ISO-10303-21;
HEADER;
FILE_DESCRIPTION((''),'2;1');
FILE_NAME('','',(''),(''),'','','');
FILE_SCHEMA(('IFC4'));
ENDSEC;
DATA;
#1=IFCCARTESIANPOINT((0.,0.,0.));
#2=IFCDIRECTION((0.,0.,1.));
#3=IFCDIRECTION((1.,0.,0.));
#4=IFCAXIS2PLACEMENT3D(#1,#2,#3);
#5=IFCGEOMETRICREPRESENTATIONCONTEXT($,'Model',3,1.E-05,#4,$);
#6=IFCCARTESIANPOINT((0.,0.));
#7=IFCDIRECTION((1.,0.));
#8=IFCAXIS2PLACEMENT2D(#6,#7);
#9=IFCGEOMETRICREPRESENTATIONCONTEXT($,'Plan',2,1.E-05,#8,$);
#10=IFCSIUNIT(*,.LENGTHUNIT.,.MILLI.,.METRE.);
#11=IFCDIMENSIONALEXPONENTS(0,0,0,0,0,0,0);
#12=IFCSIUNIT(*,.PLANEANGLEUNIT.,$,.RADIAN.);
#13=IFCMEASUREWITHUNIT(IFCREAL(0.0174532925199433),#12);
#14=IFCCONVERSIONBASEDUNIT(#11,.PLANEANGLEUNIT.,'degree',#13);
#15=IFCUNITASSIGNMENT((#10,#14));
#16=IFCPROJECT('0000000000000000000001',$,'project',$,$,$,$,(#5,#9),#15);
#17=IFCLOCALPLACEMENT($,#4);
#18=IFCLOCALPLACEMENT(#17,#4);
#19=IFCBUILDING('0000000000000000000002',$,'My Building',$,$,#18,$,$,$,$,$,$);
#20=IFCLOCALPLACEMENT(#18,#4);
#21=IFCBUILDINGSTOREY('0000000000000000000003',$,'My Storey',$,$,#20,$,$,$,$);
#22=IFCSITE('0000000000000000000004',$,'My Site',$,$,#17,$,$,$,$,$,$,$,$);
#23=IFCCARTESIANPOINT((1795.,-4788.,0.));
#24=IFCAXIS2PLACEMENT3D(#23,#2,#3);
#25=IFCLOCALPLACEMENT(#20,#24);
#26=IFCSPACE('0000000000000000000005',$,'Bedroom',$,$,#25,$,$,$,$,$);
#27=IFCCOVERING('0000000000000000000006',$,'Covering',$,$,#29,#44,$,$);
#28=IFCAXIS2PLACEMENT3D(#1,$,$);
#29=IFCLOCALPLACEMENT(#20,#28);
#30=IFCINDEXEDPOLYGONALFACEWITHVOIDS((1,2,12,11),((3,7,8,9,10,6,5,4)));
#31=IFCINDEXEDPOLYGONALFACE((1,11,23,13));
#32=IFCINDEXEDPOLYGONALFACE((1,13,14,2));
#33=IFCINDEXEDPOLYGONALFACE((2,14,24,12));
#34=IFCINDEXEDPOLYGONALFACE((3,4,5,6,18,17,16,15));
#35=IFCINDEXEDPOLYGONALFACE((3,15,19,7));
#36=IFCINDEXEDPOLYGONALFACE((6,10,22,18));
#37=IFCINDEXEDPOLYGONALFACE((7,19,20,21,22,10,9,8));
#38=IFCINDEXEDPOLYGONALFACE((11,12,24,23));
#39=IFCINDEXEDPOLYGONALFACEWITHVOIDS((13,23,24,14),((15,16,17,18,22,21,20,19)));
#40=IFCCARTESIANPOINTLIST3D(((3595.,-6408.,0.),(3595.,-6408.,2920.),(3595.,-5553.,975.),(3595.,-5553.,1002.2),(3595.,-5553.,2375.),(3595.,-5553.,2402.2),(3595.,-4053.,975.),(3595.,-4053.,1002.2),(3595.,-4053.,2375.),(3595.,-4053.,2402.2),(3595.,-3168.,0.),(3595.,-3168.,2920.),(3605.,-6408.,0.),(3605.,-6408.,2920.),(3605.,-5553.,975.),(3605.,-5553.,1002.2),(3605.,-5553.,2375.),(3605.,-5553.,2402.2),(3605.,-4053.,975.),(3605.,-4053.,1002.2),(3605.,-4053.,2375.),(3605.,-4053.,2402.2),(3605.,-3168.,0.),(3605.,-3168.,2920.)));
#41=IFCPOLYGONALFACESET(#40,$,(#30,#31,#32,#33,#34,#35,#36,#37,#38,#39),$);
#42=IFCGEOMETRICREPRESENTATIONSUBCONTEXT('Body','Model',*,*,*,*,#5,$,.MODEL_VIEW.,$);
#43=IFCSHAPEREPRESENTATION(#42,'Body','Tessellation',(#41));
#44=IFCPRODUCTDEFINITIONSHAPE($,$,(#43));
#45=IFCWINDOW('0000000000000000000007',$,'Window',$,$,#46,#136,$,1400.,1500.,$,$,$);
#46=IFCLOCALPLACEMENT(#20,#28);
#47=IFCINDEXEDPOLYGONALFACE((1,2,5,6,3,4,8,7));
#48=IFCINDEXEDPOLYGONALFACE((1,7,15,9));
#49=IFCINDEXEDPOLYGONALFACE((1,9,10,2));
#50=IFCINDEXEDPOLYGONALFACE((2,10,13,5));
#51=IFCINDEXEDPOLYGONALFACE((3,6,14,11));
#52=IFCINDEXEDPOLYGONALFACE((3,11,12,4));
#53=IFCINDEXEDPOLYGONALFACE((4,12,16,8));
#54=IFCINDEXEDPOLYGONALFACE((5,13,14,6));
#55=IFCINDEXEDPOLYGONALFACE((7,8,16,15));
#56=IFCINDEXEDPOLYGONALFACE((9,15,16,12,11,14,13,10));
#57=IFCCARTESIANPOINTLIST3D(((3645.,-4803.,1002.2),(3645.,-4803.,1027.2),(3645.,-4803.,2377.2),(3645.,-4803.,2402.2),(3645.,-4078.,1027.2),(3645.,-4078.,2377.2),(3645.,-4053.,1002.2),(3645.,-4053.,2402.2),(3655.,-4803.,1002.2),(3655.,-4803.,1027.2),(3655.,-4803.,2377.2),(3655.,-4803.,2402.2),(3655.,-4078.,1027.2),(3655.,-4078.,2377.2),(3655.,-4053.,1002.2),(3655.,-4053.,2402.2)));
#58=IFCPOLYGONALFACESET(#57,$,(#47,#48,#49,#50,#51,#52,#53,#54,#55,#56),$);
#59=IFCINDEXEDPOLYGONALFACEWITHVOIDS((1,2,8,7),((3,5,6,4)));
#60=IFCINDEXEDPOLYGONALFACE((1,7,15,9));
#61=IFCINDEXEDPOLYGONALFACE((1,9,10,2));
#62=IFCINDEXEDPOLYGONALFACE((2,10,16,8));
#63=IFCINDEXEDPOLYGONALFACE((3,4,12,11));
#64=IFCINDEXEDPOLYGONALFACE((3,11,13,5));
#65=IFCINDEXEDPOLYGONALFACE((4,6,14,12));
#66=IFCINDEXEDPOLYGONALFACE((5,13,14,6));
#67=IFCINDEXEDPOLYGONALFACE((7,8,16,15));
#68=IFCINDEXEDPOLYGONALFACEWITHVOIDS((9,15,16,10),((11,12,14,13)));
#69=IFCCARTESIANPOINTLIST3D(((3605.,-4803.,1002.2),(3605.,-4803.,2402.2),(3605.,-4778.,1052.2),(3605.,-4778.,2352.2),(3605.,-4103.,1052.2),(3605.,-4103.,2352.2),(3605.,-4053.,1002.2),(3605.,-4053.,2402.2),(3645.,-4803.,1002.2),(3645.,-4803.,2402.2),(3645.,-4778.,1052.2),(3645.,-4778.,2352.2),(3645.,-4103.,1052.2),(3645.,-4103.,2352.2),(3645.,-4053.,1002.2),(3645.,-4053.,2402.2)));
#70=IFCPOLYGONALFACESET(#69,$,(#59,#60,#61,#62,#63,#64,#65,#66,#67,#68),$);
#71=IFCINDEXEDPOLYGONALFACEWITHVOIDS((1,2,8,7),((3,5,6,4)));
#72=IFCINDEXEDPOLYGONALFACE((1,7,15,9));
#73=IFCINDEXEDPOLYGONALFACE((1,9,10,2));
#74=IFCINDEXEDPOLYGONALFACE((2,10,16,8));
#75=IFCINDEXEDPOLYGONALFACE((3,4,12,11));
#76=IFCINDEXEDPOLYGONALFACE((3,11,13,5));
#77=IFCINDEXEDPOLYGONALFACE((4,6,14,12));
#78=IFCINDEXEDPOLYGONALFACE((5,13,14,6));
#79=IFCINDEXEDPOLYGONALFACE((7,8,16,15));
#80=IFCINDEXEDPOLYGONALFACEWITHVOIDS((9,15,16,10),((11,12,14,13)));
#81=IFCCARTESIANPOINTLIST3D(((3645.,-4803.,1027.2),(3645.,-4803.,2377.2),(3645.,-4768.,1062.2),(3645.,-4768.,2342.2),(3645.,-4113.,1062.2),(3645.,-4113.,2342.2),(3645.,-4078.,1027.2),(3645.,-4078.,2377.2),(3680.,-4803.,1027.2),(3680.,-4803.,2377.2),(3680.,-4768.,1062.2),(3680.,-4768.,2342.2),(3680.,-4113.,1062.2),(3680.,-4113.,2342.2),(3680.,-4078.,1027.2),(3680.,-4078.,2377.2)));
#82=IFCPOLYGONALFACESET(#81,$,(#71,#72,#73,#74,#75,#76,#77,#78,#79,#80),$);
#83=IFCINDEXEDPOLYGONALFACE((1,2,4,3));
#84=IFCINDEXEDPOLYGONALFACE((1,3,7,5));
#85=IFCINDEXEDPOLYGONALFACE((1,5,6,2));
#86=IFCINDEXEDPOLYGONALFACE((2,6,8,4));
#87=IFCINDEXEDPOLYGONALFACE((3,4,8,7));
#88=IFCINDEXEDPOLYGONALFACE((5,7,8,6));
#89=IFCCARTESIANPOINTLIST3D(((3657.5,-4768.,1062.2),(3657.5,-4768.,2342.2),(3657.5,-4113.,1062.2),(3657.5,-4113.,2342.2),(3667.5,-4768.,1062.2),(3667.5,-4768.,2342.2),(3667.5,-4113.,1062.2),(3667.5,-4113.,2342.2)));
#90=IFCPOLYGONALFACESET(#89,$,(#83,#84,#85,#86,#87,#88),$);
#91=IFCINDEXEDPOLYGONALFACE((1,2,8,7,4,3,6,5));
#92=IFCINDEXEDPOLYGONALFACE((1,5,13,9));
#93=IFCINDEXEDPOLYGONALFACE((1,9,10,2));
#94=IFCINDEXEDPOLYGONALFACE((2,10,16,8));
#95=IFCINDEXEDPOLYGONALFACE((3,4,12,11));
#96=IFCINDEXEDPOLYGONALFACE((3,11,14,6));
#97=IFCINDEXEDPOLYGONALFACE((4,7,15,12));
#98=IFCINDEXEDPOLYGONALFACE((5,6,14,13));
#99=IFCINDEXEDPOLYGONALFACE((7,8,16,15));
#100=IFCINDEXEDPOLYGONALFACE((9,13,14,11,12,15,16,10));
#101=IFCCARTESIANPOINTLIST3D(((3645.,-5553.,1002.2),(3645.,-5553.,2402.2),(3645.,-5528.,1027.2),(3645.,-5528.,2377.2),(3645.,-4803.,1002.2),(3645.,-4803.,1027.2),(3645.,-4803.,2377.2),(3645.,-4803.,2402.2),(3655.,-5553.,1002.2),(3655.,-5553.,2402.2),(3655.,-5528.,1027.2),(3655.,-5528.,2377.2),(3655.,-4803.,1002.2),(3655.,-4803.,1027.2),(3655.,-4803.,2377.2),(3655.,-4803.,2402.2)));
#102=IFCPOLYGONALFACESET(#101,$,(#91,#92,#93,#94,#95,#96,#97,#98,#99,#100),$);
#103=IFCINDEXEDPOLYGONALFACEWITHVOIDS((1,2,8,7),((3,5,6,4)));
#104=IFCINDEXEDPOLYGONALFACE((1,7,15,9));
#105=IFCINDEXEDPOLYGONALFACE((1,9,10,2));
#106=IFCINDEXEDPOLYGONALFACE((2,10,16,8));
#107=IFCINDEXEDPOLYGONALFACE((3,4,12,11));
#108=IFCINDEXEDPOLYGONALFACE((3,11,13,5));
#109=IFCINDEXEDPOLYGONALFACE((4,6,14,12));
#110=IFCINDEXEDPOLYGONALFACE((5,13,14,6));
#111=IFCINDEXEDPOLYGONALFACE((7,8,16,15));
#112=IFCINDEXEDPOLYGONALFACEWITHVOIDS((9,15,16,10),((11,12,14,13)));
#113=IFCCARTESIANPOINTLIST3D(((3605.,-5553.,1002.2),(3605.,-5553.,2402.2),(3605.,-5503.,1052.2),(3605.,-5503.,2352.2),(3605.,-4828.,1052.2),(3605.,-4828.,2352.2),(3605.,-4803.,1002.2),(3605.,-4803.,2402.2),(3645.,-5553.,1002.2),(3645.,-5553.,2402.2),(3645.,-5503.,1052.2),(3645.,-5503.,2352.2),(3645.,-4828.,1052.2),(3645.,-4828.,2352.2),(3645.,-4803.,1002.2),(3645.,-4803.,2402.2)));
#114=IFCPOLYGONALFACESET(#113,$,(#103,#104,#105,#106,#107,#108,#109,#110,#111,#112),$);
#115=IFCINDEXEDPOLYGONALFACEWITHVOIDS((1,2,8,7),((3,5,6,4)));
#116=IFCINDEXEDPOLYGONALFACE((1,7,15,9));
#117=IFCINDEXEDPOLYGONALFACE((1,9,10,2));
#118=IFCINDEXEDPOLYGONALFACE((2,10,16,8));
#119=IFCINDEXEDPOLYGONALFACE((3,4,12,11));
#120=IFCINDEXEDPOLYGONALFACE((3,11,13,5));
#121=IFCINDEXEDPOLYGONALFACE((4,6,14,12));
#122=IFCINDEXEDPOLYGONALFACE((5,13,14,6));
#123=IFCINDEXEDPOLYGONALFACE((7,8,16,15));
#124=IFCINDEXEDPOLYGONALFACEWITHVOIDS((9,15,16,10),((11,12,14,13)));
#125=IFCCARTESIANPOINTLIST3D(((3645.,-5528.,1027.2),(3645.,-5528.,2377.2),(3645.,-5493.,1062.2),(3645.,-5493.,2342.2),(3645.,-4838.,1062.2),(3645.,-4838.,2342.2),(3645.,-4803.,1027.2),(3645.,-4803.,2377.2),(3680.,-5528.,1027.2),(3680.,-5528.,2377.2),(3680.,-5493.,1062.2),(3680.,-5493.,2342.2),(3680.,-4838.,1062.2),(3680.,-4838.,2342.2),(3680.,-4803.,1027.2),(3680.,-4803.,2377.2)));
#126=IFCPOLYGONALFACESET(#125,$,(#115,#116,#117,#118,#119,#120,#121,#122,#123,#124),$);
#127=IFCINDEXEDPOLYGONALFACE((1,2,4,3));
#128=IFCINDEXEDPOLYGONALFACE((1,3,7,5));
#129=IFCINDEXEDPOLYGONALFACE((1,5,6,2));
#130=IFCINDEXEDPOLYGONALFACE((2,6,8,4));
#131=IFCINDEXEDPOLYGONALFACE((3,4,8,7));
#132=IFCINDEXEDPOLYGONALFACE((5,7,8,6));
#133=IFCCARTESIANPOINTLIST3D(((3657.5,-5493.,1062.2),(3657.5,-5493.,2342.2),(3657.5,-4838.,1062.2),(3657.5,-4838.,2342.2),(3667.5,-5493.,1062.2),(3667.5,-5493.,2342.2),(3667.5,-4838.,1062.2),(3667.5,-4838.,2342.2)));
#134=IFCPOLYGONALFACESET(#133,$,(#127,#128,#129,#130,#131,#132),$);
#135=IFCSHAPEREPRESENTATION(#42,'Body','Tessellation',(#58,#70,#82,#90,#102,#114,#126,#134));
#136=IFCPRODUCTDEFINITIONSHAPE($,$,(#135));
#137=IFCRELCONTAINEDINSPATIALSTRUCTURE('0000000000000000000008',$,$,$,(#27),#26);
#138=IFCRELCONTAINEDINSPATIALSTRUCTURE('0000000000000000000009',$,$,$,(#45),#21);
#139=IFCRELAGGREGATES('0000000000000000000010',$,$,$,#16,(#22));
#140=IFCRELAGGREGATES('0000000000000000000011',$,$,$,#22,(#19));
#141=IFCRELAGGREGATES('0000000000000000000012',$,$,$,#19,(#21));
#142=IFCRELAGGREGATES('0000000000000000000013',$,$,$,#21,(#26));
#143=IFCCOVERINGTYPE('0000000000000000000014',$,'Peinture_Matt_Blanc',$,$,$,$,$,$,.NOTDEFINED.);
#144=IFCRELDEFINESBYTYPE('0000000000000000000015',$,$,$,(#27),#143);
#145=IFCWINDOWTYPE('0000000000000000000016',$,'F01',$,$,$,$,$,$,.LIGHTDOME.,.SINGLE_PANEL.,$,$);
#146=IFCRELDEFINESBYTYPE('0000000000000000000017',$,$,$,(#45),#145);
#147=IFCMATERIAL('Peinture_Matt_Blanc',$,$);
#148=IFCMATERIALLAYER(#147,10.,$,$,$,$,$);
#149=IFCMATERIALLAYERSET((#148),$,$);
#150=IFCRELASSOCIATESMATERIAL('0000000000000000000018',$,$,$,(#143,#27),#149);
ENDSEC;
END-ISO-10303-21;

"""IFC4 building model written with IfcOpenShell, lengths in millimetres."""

from ifc_helpers import new_model, entity, si_unit, converted_unit, frame, origin_with_axes, origin_2d_with_axis, place, context, subcontext, project, spatial, line, indexed_curve, outline, extrude, clip, halfspace, shape, source, transform, mapped, material, layer, layer_set, layer_usage, type_object, type_shapes, element, fill, save


model = new_model("IFC4")

# Units and contexts
model_context = context("Model", 3, precision=1e-05, world=origin_with_axes())
plan_context = context("Plan", 2, precision=1e-05, world=origin_2d_with_axis())
body_context_1 = subcontext(model_context, "Body", "Model", "MODEL_VIEW")
body_context_2 = subcontext(plan_context, "Body", "Plan", "PLAN_VIEW")
ifc_project = project(units=[si_unit("LENGTHUNIT", "METRE", prefix="MILLI"), converted_unit("PLANEANGLEUNIT", "degree", entity("IfcReal", 0.0174532925199433), si_unit("PLANEANGLEUNIT", "RADIAN"), dimensions=[0, 0, 0, 0, 0, 0, 0])], contexts=[model_context, plan_context])

# Site, building, storey
site_placement = place(None, origin_with_axes())
site = spatial("IfcSite", under=ifc_project, at=site_placement, Name="My Site")
building_placement = place(site_placement, origin_with_axes())
building = spatial("IfcBuilding", under=site, at=building_placement, Name="My Building")
storey_placement = place(building_placement, origin_with_axes())
storey = spatial("IfcBuildingStorey", under=building, at=storey_placement, Name="My Storey")

# Shared definitions
space_placement = place(storey_placement, frame((1795.0, -4788.0, 0.0), z_axis=(0.0, 0.0, 1.0), x_axis=(1.0, 0.0, 0.0)))
space = spatial("IfcSpace", under=storey, at=space_placement, Name="Bedroom")

# Covering, openings, window
ifc_material_1 = material(Name="Peinture_Matt_Blanc")
ifc_layer_1 = layer(ifc_material_1, 10.0)
ifc_layer_set_1 = layer_set([ifc_layer_1])
ifc_layer_usage_1 = layer_usage(ifc_layer_set_1, "AXIS2", "POSITIVE", 0.0)
covering_type_1 = type_object("IfcCoveringType", Name="Peinture_Matt_Blanc", PredefinedType="NOTDEFINED", material=ifc_layer_set_1)
covering_1_placement = place(space_placement, frame((1810.0, -1620.0, 0.0), z_axis=(0.0, 0.0, 1.0), x_axis=(0.000002, 1.0, 0.0)))
covering_1 = element("IfcCovering", 1, at=covering_1_placement, inside=space, type_object=covering_type_1, material=ifc_layer_usage_1, Name="Covering", context=body_context_1, shape_type="Clipping", body=[
    clip(clip(extrude(outline(indexed_curve([(0.0, 0.0), (0.0, 10.0), (3240.0, 10.0), (3240.0, 0.0), (0.0, 0.0)], self_intersect=False)), origin_with_axes(), (0.0, 0.0, 1.0), 2920.0), halfspace(frame((0.0, 0.0, 2920.0), z_axis=(0.0, 0.0, 1.0), x_axis=(-1.0, 0.0, 0.0)), False)), halfspace(frame((0.0, 0.0, 2920.0), z_axis=(0.0, 0.0, 1.0), x_axis=(-1.0, 0.0, 0.0)), False)),
])
shared_shape_1 = source(origin_with_axes(), body_context_1, "Body", "SweptSolid", [
    extrude(outline(indexed_curve([(0.0, 0.0), (1500.0, 0.0), (1500.0, 1400.0), (0.0, 1400.0)], segments=[line(1, 2, 3, 4, 1)])), frame((0.0, -100.0, 0.0), z_axis=(0.0, -1.0, 0.0), x_axis=(1.0, 0.0, 0.0)), (0.0, 0.0, -1.0), 210.0),
])
opening_1_placement = place(covering_1_placement, frame((2355.0, -75.0, 975.0), z_axis=(0.0, 0.0, 1.0), x_axis=(-1.0, 0.0, 0.0)))
opening_1 = element("IfcOpeningElement", 2, at=opening_1_placement, cuts=covering_1, PredefinedType="OPENING", context=body_context_1, shape_type="MappedRepresentation", body=[
    mapped(shared_shape_1, transform((0.0, 0.0, 0.0), x_axis=(1.0, 0.0, 0.0), y_axis=(0.0, 1.0, 0.0), z_axis=(0.0, 0.0, 1.0), scale=1.0)),
])
shared_shape_2 = source(origin_with_axes(), body_context_1, "Body", "SweptSolid", [
    extrude(outline(indexed_curve([(0.0, 0.0), (1500.0, 0.0), (1500.0, 1400.0), (0.0, 1400.0)], segments=[line(3, 2), line(2, 1), line(1, 4), line(4, 3)], self_intersect=False)), frame((0.0, -100.0, 0.0), z_axis=(0.0, -1.0, 0.0), x_axis=(1.0, 0.0, 0.0)), (0.0, 0.0, -1.0), 400.0),
])
opening_2_placement = place(covering_1_placement, frame((855.0, -200.0, 1002.2), z_axis=(0.0, 0.0, 1.0), x_axis=(1.0, 0.0, 0.0)))
element("IfcOpeningElement", 3, at=opening_2_placement, cuts=covering_1, PredefinedType="OPENING", context=body_context_1, shape_type="MappedRepresentation", body=[
    mapped(shared_shape_2, transform((0.0, 0.0, 0.0), x_axis=(1.0, 0.0, 0.0), y_axis=(0.0, 1.0, 0.0), z_axis=(0.0, 0.0, 1.0), scale=1.0)),
])
window_type = type_object("IfcWindowType", Name="F01", PartitioningType="SINGLE_PANEL", PredefinedType="LIGHTDOME")
shared_shape_3 = source(origin_with_axes(), body_context_1, "Body", "SweptSolid", [
    extrude(outline(indexed_curve([(750.0, 0.0), (0.0, 0.0), (0.0, 1400.0), (750.0, 1400.0), (750.0, 1375.0), (25.0, 1375.0), (25.0, 25.0), (750.0, 25.0)], segments=[line(1, 2, 3, 4, 5, 6, 7, 8, 1)])), frame((0.0, 90.0, 0.0), z_axis=(0.0, -1.0, 0.0), x_axis=(1.0, 0.0, 0.0)), (0.0, 0.0, -1.0), 10.0),
    extrude(outline(indexed_curve([(0.0, 0.0), (750.0, 0.0), (750.0, 1400.0), (0.0, 1400.0)], segments=[line(1, 2, 3, 4, 1)]), holes=[indexed_curve([(50.0, 50.0), (725.0, 50.0), (725.0, 1350.0), (50.0, 1350.0)], segments=[line(1, 2, 3, 4, 1)])]), frame((0.0, 50.0, 0.0), z_axis=(0.0, -1.0, 0.0), x_axis=(1.0, 0.0, 0.0)), (0.0, 0.0, -1.0), 40.0),
    extrude(outline(indexed_curve([(0.0, 0.0), (725.0, 0.0), (725.0, 1350.0), (0.0, 1350.0)], segments=[line(1, 2, 3, 4, 1)]), holes=[indexed_curve([(35.0, 35.0), (690.0, 35.0), (690.0, 1315.0), (35.0, 1315.0)], segments=[line(1, 2, 3, 4, 1)])]), frame((25.0, 90.0, 25.0), z_axis=(0.0, -1.0, 0.0), x_axis=(1.0, 0.0, 0.0)), (0.0, 0.0, -1.0), 35.0),
    extrude(outline(indexed_curve([(35.0, 35.0), (690.0, 35.0), (690.0, 1315.0), (35.0, 1315.0)], segments=[line(1, 2, 3, 4, 1)])), frame((25.0, 102.5, 25.0), z_axis=(0.0, -1.0, 0.0), x_axis=(1.0, 0.0, 0.0)), (0.0, 0.0, -1.0), 10.0),
    extrude(outline(indexed_curve([(0.0, 1400.0), (750.0, 1400.0), (750.0, 0.0), (0.0, 0.0), (0.0, 25.0), (725.0, 25.0), (725.0, 1375.0), (0.0, 1375.0)], segments=[line(1, 2, 3, 4, 5, 6, 7, 8, 1)])), frame((750.0, 90.0, 0.0), z_axis=(0.0, -1.0, 0.0), x_axis=(1.0, 0.0, 0.0)), (0.0, 0.0, -1.0), 10.0),
    extrude(outline(indexed_curve([(0.0, 0.0), (750.0, 0.0), (750.0, 1400.0), (0.0, 1400.0)], segments=[line(1, 2, 3, 4, 1)]), holes=[indexed_curve([(25.0, 50.0), (700.0, 50.0), (700.0, 1350.0), (25.0, 1350.0)], segments=[line(1, 2, 3, 4, 1)])]), frame((750.0, 50.0, 0.0), z_axis=(0.0, -1.0, 0.0), x_axis=(1.0, 0.0, 0.0)), (0.0, 0.0, -1.0), 40.0),
    extrude(outline(indexed_curve([(0.0, 0.0), (725.0, 0.0), (725.0, 1350.0), (0.0, 1350.0)], segments=[line(1, 2, 3, 4, 1)]), holes=[indexed_curve([(35.0, 35.0), (690.0, 35.0), (690.0, 1315.0), (35.0, 1315.0)], segments=[line(1, 2, 3, 4, 1)])]), frame((750.0, 90.0, 25.0), z_axis=(0.0, -1.0, 0.0), x_axis=(1.0, 0.0, 0.0)), (0.0, 0.0, -1.0), 35.0),
    extrude(outline(indexed_curve([(35.0, 35.0), (690.0, 35.0), (690.0, 1315.0), (35.0, 1315.0)], segments=[line(1, 2, 3, 4, 1)])), frame((750.0, 102.5, 25.0), z_axis=(0.0, -1.0, 0.0), x_axis=(1.0, 0.0, 0.0)), (0.0, 0.0, -1.0), 10.0),
])
shared_shape_4 = source(origin_with_axes(), body_context_2, "Body", "Curve2D", [
    entity("IfcIndexedPolyCurve", entity("IfcCartesianPointList2D", [[50.0, 50.0], [725.0, 50.0]])),
    entity("IfcIndexedPolyCurve", entity("IfcCartesianPointList2D", [[0.0, 100.0], [25.0, 100.0], [25.0, 90.0], [50.0, 90.0], [50.0, 50.0], [0.0, 50.0]]), [entity("IfcLineIndex", [1, 2, 3, 4, 5, 6, 1])]),
    entity("IfcIndexedPolyCurve", entity("IfcCartesianPointList2D", [[750.0, 100.0], [750.0, 100.0], [750.0, 90.0], [725.0, 90.0], [725.0, 50.0], [750.0, 50.0]])),
    entity("IfcIndexedPolyCurve", entity("IfcCartesianPointList2D", [[25.0, 90.0], [60.0, 90.0], [60.0, 125.0], [25.0, 125.0]]), [entity("IfcLineIndex", [1, 2, 3, 4, 1])]),
    entity("IfcIndexedPolyCurve", entity("IfcCartesianPointList2D", [[750.0, 90.0], [715.0, 90.0], [715.0, 125.0], [750.0, 125.0]]), [entity("IfcLineIndex", [1, 2, 3, 4, 1])]),
    entity("IfcIndexedPolyCurve", entity("IfcCartesianPointList2D", [[60.0, 90.0], [715.0, 90.0]])),
    entity("IfcIndexedPolyCurve", entity("IfcCartesianPointList2D", [[60.0, 125.0], [715.0, 125.0]])),
    entity("IfcIndexedPolyCurve", entity("IfcCartesianPointList2D", [[60.0, 107.5], [715.0, 107.5]])),
    entity("IfcIndexedPolyCurve", entity("IfcCartesianPointList2D", [[775.0, 50.0], [1450.0, 50.0]])),
    entity("IfcIndexedPolyCurve", entity("IfcCartesianPointList2D", [[750.0, 100.0], [750.0, 100.0], [750.0, 90.0], [775.0, 90.0], [775.0, 50.0], [750.0, 50.0]])),
    entity("IfcIndexedPolyCurve", entity("IfcCartesianPointList2D", [[1500.0, 100.0], [1475.0, 100.0], [1475.0, 90.0], [1450.0, 90.0], [1450.0, 50.0], [1500.0, 50.0]]), [entity("IfcLineIndex", [1, 2, 3, 4, 5, 6, 1])]),
    entity("IfcIndexedPolyCurve", entity("IfcCartesianPointList2D", [[750.0, 90.0], [785.0, 90.0], [785.0, 125.0], [750.0, 125.0]]), [entity("IfcLineIndex", [1, 2, 3, 4, 1])]),
    entity("IfcIndexedPolyCurve", entity("IfcCartesianPointList2D", [[1475.0, 90.0], [1440.0, 90.0], [1440.0, 125.0], [1475.0, 125.0]]), [entity("IfcLineIndex", [1, 2, 3, 4, 1])]),
    entity("IfcIndexedPolyCurve", entity("IfcCartesianPointList2D", [[785.0, 90.0], [1440.0, 90.0]])),
    entity("IfcIndexedPolyCurve", entity("IfcCartesianPointList2D", [[785.0, 125.0], [1440.0, 125.0]])),
    entity("IfcIndexedPolyCurve", entity("IfcCartesianPointList2D", [[785.0, 107.5], [1440.0, 107.5]])),
])
type_shapes(window_type, [shared_shape_3, shared_shape_4])
window_placement = place(opening_1_placement, frame((0.0, -125.0, 27.2), z_axis=(0.0, 0.0, 1.0), x_axis=(1.0, 0.0, 0.0)))
window = element("IfcWindow", 4, at=window_placement, inside=storey, type_object=window_type, Name="Window", OverallHeight=1400.0, OverallWidth=1500.0, shapes=[
    shape(body_context_1, "Body", "MappedRepresentation", [mapped(shared_shape_3, transform((0.0, 0.0, 0.0), x_axis=(1.0, 0.0, 0.0), y_axis=(0.0, 1.0, 0.0), z_axis=(0.0, 0.0, 1.0), scale=1.0))]),
    shape(body_context_2, "Body", "MappedRepresentation", [mapped(shared_shape_4, transform((0.0, 0.0, 0.0), x_axis=(1.0, 0.0, 0.0), y_axis=(0.0, 1.0, 0.0), z_axis=(0.0, 0.0, 1.0), scale=1.0))]),
])
fill(opening_1, window)

save(model, "model.ifc")
